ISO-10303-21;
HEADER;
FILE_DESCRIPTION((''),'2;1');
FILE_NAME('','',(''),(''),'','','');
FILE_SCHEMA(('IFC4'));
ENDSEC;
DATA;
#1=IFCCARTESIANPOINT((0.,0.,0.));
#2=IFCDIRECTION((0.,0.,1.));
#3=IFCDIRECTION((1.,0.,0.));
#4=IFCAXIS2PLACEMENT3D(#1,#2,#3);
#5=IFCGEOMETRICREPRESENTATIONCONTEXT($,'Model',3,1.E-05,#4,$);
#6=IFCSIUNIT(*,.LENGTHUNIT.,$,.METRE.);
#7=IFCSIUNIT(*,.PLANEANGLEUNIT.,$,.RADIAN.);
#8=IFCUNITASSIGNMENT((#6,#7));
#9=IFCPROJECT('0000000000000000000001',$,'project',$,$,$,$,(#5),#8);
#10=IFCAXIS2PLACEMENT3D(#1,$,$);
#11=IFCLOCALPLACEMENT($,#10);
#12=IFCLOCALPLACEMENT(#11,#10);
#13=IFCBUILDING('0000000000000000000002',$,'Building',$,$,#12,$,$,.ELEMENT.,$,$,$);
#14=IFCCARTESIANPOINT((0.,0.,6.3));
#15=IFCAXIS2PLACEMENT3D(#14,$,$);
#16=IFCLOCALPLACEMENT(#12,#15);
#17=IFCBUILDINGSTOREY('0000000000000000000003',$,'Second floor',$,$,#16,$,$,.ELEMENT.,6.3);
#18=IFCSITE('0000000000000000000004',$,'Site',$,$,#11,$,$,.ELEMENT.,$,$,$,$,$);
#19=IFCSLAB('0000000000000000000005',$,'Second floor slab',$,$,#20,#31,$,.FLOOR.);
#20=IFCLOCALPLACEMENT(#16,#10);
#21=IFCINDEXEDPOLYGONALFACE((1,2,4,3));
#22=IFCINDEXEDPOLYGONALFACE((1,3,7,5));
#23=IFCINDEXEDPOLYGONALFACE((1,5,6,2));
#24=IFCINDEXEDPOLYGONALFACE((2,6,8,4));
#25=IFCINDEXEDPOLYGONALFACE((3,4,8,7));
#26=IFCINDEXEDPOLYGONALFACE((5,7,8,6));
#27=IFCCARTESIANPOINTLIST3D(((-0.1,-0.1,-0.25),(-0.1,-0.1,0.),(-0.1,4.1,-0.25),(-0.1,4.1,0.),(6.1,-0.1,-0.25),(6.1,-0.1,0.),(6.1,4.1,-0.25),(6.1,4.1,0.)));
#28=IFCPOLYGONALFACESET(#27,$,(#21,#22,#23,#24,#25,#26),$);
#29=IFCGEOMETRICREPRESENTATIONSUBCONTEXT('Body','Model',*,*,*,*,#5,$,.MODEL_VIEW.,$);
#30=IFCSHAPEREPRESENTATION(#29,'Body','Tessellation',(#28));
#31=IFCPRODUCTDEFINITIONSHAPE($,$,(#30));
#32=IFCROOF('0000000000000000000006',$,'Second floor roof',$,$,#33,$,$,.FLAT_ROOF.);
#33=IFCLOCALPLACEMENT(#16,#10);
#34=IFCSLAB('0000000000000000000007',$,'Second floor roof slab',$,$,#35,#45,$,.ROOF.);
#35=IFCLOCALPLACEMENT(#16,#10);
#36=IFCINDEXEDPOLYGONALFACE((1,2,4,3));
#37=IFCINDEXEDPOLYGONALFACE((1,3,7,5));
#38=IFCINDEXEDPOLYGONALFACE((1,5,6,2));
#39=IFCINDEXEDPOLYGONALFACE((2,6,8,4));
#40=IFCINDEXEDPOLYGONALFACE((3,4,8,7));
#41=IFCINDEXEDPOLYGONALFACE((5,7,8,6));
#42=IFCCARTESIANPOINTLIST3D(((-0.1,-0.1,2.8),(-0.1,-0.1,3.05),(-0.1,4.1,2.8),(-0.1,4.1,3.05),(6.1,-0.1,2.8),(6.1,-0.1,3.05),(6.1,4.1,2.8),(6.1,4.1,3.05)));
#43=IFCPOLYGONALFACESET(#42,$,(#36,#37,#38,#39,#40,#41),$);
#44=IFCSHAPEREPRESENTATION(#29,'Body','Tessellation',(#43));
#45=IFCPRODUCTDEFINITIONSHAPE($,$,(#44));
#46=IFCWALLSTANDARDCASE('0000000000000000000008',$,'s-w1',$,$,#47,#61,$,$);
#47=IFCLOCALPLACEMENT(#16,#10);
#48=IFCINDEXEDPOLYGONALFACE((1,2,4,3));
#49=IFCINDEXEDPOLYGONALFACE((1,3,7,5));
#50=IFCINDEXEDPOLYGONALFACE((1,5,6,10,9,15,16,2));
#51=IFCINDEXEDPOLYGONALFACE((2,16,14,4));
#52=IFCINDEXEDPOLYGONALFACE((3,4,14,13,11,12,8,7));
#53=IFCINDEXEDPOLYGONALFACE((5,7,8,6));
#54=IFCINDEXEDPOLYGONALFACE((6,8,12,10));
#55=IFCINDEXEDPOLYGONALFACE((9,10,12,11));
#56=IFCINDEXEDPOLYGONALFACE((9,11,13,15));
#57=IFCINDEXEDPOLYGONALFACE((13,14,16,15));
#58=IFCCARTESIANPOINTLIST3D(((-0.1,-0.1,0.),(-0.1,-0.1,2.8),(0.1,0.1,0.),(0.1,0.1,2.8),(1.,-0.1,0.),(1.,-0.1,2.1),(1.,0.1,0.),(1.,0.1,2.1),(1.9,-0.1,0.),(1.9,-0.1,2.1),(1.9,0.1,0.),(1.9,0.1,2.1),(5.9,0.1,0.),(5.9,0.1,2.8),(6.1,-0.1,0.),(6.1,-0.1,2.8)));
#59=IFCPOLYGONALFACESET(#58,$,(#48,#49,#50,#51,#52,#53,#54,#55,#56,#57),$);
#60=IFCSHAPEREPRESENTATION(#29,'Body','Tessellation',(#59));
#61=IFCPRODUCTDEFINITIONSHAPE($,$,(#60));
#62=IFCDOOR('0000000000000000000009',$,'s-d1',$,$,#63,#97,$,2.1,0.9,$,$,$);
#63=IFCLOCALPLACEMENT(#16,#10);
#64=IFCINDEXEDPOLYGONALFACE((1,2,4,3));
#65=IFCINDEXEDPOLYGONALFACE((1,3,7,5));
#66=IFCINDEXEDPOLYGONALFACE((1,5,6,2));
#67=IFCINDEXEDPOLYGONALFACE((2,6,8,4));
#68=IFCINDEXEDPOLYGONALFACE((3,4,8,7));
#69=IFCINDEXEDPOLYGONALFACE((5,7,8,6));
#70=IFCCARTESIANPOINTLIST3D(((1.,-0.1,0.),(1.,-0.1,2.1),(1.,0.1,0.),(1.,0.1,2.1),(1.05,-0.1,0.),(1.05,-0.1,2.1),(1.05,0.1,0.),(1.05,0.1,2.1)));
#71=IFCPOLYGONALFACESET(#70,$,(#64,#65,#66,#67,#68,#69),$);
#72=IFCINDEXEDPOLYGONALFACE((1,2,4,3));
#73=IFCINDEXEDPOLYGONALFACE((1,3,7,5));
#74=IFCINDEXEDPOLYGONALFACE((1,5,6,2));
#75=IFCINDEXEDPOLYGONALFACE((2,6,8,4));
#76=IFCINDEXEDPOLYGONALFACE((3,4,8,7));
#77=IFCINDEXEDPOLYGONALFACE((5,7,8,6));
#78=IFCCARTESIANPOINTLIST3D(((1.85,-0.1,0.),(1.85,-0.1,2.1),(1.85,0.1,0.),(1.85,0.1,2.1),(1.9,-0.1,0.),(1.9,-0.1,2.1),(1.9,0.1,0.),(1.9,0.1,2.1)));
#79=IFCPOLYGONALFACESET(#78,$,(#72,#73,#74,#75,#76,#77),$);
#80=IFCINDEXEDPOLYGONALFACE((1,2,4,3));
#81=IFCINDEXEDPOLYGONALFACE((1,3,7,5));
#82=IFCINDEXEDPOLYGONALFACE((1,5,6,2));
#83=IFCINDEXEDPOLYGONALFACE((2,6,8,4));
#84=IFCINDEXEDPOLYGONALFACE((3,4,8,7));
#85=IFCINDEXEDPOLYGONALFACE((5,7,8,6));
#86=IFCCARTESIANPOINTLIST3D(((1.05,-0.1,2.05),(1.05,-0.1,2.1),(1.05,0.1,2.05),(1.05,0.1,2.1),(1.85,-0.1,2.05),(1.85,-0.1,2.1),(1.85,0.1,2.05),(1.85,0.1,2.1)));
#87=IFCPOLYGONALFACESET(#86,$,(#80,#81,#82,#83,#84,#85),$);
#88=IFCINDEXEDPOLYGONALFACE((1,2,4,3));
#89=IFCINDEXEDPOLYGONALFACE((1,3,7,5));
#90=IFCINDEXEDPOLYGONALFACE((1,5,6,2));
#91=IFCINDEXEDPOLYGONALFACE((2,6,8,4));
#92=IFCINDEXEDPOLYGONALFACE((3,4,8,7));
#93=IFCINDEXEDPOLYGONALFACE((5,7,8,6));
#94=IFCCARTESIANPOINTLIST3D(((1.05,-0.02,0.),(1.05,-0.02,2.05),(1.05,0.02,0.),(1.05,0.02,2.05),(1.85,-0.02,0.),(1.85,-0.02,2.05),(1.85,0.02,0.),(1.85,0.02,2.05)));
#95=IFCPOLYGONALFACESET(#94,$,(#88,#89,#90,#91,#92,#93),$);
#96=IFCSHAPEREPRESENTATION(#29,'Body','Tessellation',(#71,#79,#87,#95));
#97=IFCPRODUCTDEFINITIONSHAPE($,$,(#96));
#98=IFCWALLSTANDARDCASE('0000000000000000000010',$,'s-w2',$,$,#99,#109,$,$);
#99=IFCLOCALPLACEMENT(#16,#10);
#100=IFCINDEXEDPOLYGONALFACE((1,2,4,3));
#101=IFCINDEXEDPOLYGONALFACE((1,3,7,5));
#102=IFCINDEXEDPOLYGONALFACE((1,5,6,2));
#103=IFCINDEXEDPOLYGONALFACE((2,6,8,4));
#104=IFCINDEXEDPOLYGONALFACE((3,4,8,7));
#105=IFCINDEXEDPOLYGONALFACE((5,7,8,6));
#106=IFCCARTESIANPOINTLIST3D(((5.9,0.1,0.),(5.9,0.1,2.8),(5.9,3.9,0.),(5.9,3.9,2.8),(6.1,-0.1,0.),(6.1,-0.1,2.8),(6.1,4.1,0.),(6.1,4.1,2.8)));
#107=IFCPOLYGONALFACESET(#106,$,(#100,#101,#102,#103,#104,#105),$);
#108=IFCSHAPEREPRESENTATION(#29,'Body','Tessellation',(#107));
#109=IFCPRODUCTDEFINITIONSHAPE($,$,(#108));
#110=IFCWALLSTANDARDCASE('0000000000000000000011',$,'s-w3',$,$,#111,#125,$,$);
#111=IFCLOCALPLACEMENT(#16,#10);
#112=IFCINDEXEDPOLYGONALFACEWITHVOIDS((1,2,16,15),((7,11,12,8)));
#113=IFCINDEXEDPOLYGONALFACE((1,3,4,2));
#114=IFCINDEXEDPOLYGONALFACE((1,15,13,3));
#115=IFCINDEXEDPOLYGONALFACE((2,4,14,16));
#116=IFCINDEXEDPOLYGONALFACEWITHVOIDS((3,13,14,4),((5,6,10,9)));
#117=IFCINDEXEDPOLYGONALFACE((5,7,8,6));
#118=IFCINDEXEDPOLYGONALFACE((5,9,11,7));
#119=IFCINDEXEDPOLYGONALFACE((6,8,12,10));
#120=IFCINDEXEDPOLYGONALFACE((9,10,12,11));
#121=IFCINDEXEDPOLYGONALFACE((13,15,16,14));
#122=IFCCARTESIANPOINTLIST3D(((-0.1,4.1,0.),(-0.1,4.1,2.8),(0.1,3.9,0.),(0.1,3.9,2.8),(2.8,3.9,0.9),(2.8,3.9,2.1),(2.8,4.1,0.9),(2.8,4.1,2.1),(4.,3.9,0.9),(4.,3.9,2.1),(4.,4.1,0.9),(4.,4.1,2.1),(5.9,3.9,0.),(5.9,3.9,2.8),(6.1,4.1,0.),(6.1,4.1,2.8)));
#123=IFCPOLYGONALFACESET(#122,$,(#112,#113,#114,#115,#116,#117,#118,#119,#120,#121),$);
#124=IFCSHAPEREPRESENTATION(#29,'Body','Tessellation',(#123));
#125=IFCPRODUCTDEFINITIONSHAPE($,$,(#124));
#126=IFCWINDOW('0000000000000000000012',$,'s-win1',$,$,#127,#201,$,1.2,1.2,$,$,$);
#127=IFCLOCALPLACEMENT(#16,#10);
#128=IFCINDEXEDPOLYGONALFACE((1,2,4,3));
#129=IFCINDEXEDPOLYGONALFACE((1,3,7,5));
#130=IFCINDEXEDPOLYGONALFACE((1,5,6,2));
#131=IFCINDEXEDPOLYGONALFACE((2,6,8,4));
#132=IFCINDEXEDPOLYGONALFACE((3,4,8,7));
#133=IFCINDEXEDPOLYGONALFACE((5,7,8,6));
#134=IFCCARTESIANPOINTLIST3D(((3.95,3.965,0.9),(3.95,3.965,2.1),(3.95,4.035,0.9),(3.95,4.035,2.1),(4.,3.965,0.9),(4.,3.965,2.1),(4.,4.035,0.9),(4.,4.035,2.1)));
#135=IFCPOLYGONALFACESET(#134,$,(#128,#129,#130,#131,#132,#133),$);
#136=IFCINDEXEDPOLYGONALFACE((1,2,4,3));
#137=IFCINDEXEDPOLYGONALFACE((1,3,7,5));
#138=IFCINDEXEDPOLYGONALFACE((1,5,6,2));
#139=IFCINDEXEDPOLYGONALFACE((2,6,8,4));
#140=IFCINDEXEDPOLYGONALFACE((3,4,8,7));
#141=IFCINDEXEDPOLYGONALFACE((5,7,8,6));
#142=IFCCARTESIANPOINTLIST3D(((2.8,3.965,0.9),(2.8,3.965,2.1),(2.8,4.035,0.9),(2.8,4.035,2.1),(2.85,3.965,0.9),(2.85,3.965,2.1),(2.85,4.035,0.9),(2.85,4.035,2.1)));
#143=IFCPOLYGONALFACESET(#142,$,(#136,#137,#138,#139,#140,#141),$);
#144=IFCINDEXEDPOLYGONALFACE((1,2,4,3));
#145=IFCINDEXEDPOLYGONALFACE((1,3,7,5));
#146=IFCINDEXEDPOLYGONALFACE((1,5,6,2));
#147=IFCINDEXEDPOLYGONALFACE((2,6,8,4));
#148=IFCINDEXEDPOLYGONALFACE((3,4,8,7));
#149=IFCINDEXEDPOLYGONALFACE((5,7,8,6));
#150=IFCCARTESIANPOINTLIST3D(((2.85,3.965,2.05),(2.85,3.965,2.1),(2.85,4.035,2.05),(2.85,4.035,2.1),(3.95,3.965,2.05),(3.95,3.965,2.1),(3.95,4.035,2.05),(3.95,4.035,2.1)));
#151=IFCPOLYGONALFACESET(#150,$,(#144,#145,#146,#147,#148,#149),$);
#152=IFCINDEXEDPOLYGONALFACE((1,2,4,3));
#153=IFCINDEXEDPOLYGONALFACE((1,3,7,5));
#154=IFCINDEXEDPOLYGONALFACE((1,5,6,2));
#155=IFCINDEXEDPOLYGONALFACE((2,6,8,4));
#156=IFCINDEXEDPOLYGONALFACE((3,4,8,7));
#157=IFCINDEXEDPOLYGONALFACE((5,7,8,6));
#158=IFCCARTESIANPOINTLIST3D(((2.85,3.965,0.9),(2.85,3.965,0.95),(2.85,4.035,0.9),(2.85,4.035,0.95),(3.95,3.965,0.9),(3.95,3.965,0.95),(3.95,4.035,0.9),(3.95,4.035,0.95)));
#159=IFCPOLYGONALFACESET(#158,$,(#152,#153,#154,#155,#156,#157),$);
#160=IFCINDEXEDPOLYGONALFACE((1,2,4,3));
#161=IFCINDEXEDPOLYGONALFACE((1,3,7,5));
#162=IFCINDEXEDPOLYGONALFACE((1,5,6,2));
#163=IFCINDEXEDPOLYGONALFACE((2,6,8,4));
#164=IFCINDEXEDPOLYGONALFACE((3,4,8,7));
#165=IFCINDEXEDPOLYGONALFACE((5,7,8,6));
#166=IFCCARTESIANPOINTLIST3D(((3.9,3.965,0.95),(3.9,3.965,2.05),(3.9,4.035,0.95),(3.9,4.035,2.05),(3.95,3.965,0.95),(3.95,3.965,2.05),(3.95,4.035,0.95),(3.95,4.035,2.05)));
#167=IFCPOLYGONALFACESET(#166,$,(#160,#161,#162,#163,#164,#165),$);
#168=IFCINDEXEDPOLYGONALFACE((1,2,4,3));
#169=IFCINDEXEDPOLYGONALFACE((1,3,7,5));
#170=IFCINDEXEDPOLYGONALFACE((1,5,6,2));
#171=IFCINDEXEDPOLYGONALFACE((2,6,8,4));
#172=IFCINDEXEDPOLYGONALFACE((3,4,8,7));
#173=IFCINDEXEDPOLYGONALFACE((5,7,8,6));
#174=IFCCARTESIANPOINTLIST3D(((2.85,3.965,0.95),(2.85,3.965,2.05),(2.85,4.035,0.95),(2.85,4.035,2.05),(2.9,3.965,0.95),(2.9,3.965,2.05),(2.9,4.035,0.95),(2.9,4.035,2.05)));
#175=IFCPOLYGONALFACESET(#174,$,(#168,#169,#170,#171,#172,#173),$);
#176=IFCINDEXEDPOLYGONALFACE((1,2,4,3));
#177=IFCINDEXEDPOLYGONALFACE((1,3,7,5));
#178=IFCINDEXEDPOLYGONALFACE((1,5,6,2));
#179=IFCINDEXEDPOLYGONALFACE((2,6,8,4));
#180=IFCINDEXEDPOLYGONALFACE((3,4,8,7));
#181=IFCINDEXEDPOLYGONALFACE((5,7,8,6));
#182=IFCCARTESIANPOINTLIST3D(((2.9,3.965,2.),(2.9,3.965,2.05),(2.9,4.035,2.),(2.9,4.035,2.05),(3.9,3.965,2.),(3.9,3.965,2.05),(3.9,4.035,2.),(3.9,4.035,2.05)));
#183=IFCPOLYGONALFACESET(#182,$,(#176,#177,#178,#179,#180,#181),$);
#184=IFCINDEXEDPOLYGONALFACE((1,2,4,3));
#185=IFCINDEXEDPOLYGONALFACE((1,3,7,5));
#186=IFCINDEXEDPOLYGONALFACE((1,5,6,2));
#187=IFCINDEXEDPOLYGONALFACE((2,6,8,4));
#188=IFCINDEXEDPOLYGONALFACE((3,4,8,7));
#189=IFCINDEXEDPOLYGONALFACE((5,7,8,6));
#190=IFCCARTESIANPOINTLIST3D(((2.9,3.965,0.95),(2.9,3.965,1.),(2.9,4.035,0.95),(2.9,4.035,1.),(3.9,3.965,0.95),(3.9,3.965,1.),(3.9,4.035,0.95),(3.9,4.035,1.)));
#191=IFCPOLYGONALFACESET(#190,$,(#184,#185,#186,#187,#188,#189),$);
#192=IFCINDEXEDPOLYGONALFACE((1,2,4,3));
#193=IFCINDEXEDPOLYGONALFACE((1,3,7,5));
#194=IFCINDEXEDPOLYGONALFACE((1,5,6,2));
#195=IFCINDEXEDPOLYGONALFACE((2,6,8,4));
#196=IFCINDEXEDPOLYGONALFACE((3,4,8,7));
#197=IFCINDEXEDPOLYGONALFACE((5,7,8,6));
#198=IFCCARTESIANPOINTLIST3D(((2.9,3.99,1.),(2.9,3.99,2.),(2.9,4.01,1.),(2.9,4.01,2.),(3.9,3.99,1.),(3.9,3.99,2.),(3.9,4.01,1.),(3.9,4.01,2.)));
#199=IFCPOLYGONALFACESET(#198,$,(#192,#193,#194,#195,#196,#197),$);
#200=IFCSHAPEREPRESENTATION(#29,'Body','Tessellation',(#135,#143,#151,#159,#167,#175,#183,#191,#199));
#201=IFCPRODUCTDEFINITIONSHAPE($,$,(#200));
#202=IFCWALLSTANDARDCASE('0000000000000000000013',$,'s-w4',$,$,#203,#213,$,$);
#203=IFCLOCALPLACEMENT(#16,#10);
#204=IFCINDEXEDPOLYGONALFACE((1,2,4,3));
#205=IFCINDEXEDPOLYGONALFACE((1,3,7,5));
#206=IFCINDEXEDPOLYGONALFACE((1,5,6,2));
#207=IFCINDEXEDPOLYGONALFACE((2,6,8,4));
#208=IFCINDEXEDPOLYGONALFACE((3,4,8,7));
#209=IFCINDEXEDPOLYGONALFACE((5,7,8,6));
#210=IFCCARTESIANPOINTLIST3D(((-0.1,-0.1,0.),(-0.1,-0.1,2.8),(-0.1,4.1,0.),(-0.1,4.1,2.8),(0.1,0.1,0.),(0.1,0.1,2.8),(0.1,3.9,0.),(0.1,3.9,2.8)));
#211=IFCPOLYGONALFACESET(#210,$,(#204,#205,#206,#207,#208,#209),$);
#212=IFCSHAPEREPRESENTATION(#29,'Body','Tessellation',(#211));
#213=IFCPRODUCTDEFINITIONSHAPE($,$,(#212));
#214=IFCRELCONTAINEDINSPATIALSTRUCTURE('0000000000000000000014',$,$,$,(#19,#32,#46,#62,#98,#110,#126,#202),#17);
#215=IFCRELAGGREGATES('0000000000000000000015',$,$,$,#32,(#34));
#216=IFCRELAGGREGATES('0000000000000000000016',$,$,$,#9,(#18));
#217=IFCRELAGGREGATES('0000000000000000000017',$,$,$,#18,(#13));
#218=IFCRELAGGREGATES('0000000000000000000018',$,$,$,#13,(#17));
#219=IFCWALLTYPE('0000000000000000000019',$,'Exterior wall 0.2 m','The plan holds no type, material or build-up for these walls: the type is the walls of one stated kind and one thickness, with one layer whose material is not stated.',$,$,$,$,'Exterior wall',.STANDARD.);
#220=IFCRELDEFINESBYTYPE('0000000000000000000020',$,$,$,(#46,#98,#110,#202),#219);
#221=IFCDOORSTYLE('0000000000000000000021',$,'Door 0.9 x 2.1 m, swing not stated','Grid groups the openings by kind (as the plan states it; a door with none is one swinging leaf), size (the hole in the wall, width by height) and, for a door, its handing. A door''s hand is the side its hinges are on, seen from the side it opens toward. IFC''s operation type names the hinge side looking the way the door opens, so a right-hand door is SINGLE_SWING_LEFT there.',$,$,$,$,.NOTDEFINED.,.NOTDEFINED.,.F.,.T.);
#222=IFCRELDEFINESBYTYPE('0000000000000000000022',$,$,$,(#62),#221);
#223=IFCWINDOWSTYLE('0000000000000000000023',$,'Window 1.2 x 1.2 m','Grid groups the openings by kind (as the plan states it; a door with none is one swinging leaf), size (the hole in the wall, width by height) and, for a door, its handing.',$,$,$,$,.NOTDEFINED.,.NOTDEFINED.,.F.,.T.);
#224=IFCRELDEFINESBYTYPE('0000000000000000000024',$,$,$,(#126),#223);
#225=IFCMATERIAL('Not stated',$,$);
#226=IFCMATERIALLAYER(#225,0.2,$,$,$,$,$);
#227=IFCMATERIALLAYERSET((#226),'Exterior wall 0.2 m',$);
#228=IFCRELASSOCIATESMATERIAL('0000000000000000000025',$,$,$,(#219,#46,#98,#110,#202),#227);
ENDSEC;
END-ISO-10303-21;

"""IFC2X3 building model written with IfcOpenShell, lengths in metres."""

from ifc_helpers import new_model, si_unit, frame, frame_2d, origin, origin_with_axes, place, context, subcontext, project, spatial, polyline, rectangle, outline, extrude, material, layer, layer_set, layer_usage, type_object, element, fill, aggregate, save


model = new_model("IFC2X3")

# Units and contexts
model_context = context("Model", 3, precision=1e-05, world=origin_with_axes())
body_context = subcontext(model_context, "Body", "Model", "MODEL_VIEW")
ifc_project = project(units=[si_unit("LENGTHUNIT", "METRE"), si_unit("PLANEANGLEUNIT", "RADIAN")], contexts=[model_context])

# Site, building, storey
site_placement = place(None, origin())
site = spatial("IfcSite", under=ifc_project, at=site_placement, Name="Site", CompositionType="ELEMENT")
building_placement = place(site_placement, origin())
building = spatial("IfcBuilding", under=site, at=building_placement, Name="Building", CompositionType="ELEMENT")
storey_placement = place(building_placement, frame((0.0, 0.0, 6.3)))
storey = spatial("IfcBuildingStorey", under=building, at=storey_placement, Name="Second floor", CompositionType="ELEMENT", Elevation=6.3)

# Slab
slab_1_placement = place(storey_placement, frame((0.0, 0.0, -0.25)))
element("IfcSlab", 1, at=slab_1_placement, inside=storey, Name="Second floor slab", PredefinedType="FLOOR", context=body_context, shape_type="SweptSolid", body=[
    extrude(outline(polyline([(-0.1, -0.1), (6.1, -0.1), (6.1, 4.1), (-0.1, 4.1), (-0.1, -0.1)])), origin(), (0.0, 0.0, 1.0), 0.25),
])

# Roof, slab
roof_placement = place(storey_placement, origin())
roof = element("IfcRoof", 2, at=roof_placement, inside=storey, Name="Second floor roof", ShapeType="FLAT_ROOF")
slab_2_placement = place(storey_placement, frame((0.0, 0.0, 2.8)))
slab_2 = element("IfcSlab", 3, at=slab_2_placement, Name="Second floor roof slab", PredefinedType="ROOF", context=body_context, shape_type="SweptSolid", body=[
    extrude(outline(polyline([(-0.1, -0.1), (6.1, -0.1), (6.1, 4.1), (-0.1, 4.1), (-0.1, -0.1)])), origin(), (0.0, 0.0, 1.0), 0.25),
])
aggregate(roof, [slab_2])

# Wall, opening, door
ifc_material = material(Name="Not stated")
ifc_layer = layer(ifc_material, 0.2)
ifc_layer_set = layer_set([ifc_layer], Name="Exterior wall 0.2 m")
ifc_layer_usage = layer_usage(ifc_layer_set, "AXIS2", "POSITIVE", -0.1)
wall_type = type_object("IfcWallType", Name="Exterior wall 0.2 m", Description="The plan holds no type, material or build-up for these walls: the type is the walls of one stated kind and one thickness, with one layer whose material is not stated.", ElementType="Exterior wall", PredefinedType="STANDARD", material=ifc_layer_set)
wall_1_placement = place(storey_placement, origin_with_axes())
wall_1 = element("IfcWallStandardCase", 4, at=wall_1_placement, inside=storey, type_object=wall_type, material=ifc_layer_usage, Name="s-w1", context=body_context, shape_type="SweptSolid", body=[
    extrude(outline(polyline([(-0.1, -0.1), (6.1, -0.1), (5.9, 0.1), (0.1, 0.1), (-0.1, -0.1)])), origin(), (0.0, 0.0, 1.0), 2.8),
])
opening_1_placement = place(wall_1_placement, frame((1.0, 0.0, 0.0)))
opening_1 = element("IfcOpeningElement", 5, at=opening_1_placement, cuts=wall_1, context=body_context, shape_type="SweptSolid", body=[
    extrude(rectangle(XDim=0.9, YDim=0.22, at=frame_2d((0.45, 0.0), x_axis=(1.0, 0.0))), origin(), (0.0, 0.0, 1.0), 2.1),
])
door_style = type_object("IfcDoorStyle", Name="Door 0.9 x 2.1 m, swing not stated", Description="Grid groups the openings by kind (as the plan states it; a door with none is one swinging leaf), size (the hole in the wall, width by height) and, for a door, its handing. A door's hand is the side its hinges are on, seen from the side it opens toward. IFC's operation type names the hinge side looking the way the door opens, so a right-hand door is SINGLE_SWING_LEFT there.", ConstructionType="NOTDEFINED", OperationType="NOTDEFINED", ParameterTakesPrecedence=False, Sizeable=True)
door_placement = place(opening_1_placement, origin())
door = element("IfcDoor", 6, at=door_placement, inside=storey, type_object=door_style, Name="s-d1", OverallHeight=2.1, OverallWidth=0.9, context=body_context, shape_type="SweptSolid", body=[
    extrude(rectangle(XDim=0.05, YDim=0.2, at=frame_2d((0.025, 0.0), x_axis=(1.0, 0.0))), origin(), (0.0, 0.0, 1.0), 2.1),
    extrude(rectangle(XDim=0.05, YDim=0.2, at=frame_2d((0.875, 0.0), x_axis=(1.0, 0.0))), origin(), (0.0, 0.0, 1.0), 2.1),
    extrude(rectangle(XDim=0.8, YDim=0.2, at=frame_2d((0.45, 0.0), x_axis=(1.0, 0.0))), frame((0.0, 0.0, 2.05)), (0.0, 0.0, 1.0), 0.05),
    extrude(rectangle(XDim=0.8, YDim=0.04, at=frame_2d((0.45, 0.0), x_axis=(1.0, 0.0))), origin(), (0.0, 0.0, 1.0), 2.05),
])
fill(opening_1, door)

# Wall
wall_2_placement = place(storey_placement, frame((6.0, 0.0, 0.0), z_axis=(0.0, 0.0, 1.0), x_axis=(0.0, 1.0, 0.0)))
element("IfcWallStandardCase", 7, at=wall_2_placement, inside=storey, type_object=wall_type, material=ifc_layer_usage, Name="s-w2", context=body_context, shape_type="SweptSolid", body=[
    extrude(outline(polyline([(-0.1, -0.1), (4.1, -0.1), (3.9, 0.1), (0.1, 0.1), (-0.1, -0.1)])), origin(), (0.0, 0.0, 1.0), 2.8),
])

# Wall, opening, window
wall_3_placement = place(storey_placement, frame((6.0, 4.0, 0.0), z_axis=(0.0, 0.0, 1.0), x_axis=(-1.0, 0.0, 0.0)))
wall_3 = element("IfcWallStandardCase", 8, at=wall_3_placement, inside=storey, type_object=wall_type, material=ifc_layer_usage, Name="s-w3", context=body_context, shape_type="SweptSolid", body=[
    extrude(outline(polyline([(-0.1, -0.1), (6.1, -0.1), (5.9, 0.1), (0.1, 0.1), (-0.1, -0.1)])), origin(), (0.0, 0.0, 1.0), 2.8),
])
opening_2_placement = place(wall_3_placement, frame((2.0, 0.0, 0.9)))
opening_2 = element("IfcOpeningElement", 9, at=opening_2_placement, cuts=wall_3, context=body_context, shape_type="SweptSolid", body=[
    extrude(rectangle(XDim=1.2, YDim=0.22, at=frame_2d((0.6, 0.0), x_axis=(1.0, 0.0))), origin(), (0.0, 0.0, 1.0), 1.2),
])
window_style = type_object("IfcWindowStyle", Name="Window 1.2 x 1.2 m", Description="Grid groups the openings by kind (as the plan states it; a door with none is one swinging leaf), size (the hole in the wall, width by height) and, for a door, its handing.", ConstructionType="NOTDEFINED", OperationType="NOTDEFINED", ParameterTakesPrecedence=False, Sizeable=True)
window_placement = place(opening_2_placement, origin())
window = element("IfcWindow", 10, at=window_placement, inside=storey, type_object=window_style, Name="s-win1", OverallHeight=1.2, OverallWidth=1.2, context=body_context, shape_type="SweptSolid", body=[
    extrude(rectangle(XDim=0.05, YDim=0.07, at=frame_2d((0.025, 0.0), x_axis=(1.0, 0.0))), origin(), (0.0, 0.0, 1.0), 1.2),
    extrude(rectangle(XDim=0.05, YDim=0.07, at=frame_2d((1.175, 0.0), x_axis=(1.0, 0.0))), origin(), (0.0, 0.0, 1.0), 1.2),
    extrude(rectangle(XDim=1.1, YDim=0.07, at=frame_2d((0.6, 0.0), x_axis=(1.0, 0.0))), frame((0.0, 0.0, 1.15)), (0.0, 0.0, 1.0), 0.05),
    extrude(rectangle(XDim=1.1, YDim=0.07, at=frame_2d((0.6, 0.0), x_axis=(1.0, 0.0))), origin(), (0.0, 0.0, 1.0), 0.05),
    extrude(rectangle(XDim=0.05, YDim=0.07, at=frame_2d((0.075, 0.0), x_axis=(1.0, 0.0))), frame((0.0, 0.0, 0.05)), (0.0, 0.0, 1.0), 1.1),
    extrude(rectangle(XDim=0.05, YDim=0.07, at=frame_2d((1.125, 0.0), x_axis=(1.0, 0.0))), frame((0.0, 0.0, 0.05)), (0.0, 0.0, 1.0), 1.1),
    extrude(rectangle(XDim=1.0, YDim=0.07, at=frame_2d((0.6, 0.0), x_axis=(1.0, 0.0))), frame((0.0, 0.0, 1.1)), (0.0, 0.0, 1.0), 0.05),
    extrude(rectangle(XDim=1.0, YDim=0.07, at=frame_2d((0.6, 0.0), x_axis=(1.0, 0.0))), frame((0.0, 0.0, 0.05)), (0.0, 0.0, 1.0), 0.05),
    extrude(rectangle(XDim=1.0, YDim=0.02, at=frame_2d((0.6, 0.0), x_axis=(1.0, 0.0))), frame((0.0, 0.0, 0.1)), (0.0, 0.0, 1.0), 1.0),
])
fill(opening_2, window)

# Wall
wall_4_placement = place(storey_placement, frame((0.0, 4.0, 0.0), z_axis=(0.0, 0.0, 1.0), x_axis=(0.0, -1.0, 0.0)))
element("IfcWallStandardCase", 11, at=wall_4_placement, inside=storey, type_object=wall_type, material=ifc_layer_usage, Name="s-w4", context=body_context, shape_type="SweptSolid", body=[
    extrude(outline(polyline([(-0.1, -0.1), (4.1, -0.1), (3.9, 0.1), (0.1, 0.1), (-0.1, -0.1)])), origin(), (0.0, 0.0, 1.0), 2.8),
])

save(model, "model.ifc")
